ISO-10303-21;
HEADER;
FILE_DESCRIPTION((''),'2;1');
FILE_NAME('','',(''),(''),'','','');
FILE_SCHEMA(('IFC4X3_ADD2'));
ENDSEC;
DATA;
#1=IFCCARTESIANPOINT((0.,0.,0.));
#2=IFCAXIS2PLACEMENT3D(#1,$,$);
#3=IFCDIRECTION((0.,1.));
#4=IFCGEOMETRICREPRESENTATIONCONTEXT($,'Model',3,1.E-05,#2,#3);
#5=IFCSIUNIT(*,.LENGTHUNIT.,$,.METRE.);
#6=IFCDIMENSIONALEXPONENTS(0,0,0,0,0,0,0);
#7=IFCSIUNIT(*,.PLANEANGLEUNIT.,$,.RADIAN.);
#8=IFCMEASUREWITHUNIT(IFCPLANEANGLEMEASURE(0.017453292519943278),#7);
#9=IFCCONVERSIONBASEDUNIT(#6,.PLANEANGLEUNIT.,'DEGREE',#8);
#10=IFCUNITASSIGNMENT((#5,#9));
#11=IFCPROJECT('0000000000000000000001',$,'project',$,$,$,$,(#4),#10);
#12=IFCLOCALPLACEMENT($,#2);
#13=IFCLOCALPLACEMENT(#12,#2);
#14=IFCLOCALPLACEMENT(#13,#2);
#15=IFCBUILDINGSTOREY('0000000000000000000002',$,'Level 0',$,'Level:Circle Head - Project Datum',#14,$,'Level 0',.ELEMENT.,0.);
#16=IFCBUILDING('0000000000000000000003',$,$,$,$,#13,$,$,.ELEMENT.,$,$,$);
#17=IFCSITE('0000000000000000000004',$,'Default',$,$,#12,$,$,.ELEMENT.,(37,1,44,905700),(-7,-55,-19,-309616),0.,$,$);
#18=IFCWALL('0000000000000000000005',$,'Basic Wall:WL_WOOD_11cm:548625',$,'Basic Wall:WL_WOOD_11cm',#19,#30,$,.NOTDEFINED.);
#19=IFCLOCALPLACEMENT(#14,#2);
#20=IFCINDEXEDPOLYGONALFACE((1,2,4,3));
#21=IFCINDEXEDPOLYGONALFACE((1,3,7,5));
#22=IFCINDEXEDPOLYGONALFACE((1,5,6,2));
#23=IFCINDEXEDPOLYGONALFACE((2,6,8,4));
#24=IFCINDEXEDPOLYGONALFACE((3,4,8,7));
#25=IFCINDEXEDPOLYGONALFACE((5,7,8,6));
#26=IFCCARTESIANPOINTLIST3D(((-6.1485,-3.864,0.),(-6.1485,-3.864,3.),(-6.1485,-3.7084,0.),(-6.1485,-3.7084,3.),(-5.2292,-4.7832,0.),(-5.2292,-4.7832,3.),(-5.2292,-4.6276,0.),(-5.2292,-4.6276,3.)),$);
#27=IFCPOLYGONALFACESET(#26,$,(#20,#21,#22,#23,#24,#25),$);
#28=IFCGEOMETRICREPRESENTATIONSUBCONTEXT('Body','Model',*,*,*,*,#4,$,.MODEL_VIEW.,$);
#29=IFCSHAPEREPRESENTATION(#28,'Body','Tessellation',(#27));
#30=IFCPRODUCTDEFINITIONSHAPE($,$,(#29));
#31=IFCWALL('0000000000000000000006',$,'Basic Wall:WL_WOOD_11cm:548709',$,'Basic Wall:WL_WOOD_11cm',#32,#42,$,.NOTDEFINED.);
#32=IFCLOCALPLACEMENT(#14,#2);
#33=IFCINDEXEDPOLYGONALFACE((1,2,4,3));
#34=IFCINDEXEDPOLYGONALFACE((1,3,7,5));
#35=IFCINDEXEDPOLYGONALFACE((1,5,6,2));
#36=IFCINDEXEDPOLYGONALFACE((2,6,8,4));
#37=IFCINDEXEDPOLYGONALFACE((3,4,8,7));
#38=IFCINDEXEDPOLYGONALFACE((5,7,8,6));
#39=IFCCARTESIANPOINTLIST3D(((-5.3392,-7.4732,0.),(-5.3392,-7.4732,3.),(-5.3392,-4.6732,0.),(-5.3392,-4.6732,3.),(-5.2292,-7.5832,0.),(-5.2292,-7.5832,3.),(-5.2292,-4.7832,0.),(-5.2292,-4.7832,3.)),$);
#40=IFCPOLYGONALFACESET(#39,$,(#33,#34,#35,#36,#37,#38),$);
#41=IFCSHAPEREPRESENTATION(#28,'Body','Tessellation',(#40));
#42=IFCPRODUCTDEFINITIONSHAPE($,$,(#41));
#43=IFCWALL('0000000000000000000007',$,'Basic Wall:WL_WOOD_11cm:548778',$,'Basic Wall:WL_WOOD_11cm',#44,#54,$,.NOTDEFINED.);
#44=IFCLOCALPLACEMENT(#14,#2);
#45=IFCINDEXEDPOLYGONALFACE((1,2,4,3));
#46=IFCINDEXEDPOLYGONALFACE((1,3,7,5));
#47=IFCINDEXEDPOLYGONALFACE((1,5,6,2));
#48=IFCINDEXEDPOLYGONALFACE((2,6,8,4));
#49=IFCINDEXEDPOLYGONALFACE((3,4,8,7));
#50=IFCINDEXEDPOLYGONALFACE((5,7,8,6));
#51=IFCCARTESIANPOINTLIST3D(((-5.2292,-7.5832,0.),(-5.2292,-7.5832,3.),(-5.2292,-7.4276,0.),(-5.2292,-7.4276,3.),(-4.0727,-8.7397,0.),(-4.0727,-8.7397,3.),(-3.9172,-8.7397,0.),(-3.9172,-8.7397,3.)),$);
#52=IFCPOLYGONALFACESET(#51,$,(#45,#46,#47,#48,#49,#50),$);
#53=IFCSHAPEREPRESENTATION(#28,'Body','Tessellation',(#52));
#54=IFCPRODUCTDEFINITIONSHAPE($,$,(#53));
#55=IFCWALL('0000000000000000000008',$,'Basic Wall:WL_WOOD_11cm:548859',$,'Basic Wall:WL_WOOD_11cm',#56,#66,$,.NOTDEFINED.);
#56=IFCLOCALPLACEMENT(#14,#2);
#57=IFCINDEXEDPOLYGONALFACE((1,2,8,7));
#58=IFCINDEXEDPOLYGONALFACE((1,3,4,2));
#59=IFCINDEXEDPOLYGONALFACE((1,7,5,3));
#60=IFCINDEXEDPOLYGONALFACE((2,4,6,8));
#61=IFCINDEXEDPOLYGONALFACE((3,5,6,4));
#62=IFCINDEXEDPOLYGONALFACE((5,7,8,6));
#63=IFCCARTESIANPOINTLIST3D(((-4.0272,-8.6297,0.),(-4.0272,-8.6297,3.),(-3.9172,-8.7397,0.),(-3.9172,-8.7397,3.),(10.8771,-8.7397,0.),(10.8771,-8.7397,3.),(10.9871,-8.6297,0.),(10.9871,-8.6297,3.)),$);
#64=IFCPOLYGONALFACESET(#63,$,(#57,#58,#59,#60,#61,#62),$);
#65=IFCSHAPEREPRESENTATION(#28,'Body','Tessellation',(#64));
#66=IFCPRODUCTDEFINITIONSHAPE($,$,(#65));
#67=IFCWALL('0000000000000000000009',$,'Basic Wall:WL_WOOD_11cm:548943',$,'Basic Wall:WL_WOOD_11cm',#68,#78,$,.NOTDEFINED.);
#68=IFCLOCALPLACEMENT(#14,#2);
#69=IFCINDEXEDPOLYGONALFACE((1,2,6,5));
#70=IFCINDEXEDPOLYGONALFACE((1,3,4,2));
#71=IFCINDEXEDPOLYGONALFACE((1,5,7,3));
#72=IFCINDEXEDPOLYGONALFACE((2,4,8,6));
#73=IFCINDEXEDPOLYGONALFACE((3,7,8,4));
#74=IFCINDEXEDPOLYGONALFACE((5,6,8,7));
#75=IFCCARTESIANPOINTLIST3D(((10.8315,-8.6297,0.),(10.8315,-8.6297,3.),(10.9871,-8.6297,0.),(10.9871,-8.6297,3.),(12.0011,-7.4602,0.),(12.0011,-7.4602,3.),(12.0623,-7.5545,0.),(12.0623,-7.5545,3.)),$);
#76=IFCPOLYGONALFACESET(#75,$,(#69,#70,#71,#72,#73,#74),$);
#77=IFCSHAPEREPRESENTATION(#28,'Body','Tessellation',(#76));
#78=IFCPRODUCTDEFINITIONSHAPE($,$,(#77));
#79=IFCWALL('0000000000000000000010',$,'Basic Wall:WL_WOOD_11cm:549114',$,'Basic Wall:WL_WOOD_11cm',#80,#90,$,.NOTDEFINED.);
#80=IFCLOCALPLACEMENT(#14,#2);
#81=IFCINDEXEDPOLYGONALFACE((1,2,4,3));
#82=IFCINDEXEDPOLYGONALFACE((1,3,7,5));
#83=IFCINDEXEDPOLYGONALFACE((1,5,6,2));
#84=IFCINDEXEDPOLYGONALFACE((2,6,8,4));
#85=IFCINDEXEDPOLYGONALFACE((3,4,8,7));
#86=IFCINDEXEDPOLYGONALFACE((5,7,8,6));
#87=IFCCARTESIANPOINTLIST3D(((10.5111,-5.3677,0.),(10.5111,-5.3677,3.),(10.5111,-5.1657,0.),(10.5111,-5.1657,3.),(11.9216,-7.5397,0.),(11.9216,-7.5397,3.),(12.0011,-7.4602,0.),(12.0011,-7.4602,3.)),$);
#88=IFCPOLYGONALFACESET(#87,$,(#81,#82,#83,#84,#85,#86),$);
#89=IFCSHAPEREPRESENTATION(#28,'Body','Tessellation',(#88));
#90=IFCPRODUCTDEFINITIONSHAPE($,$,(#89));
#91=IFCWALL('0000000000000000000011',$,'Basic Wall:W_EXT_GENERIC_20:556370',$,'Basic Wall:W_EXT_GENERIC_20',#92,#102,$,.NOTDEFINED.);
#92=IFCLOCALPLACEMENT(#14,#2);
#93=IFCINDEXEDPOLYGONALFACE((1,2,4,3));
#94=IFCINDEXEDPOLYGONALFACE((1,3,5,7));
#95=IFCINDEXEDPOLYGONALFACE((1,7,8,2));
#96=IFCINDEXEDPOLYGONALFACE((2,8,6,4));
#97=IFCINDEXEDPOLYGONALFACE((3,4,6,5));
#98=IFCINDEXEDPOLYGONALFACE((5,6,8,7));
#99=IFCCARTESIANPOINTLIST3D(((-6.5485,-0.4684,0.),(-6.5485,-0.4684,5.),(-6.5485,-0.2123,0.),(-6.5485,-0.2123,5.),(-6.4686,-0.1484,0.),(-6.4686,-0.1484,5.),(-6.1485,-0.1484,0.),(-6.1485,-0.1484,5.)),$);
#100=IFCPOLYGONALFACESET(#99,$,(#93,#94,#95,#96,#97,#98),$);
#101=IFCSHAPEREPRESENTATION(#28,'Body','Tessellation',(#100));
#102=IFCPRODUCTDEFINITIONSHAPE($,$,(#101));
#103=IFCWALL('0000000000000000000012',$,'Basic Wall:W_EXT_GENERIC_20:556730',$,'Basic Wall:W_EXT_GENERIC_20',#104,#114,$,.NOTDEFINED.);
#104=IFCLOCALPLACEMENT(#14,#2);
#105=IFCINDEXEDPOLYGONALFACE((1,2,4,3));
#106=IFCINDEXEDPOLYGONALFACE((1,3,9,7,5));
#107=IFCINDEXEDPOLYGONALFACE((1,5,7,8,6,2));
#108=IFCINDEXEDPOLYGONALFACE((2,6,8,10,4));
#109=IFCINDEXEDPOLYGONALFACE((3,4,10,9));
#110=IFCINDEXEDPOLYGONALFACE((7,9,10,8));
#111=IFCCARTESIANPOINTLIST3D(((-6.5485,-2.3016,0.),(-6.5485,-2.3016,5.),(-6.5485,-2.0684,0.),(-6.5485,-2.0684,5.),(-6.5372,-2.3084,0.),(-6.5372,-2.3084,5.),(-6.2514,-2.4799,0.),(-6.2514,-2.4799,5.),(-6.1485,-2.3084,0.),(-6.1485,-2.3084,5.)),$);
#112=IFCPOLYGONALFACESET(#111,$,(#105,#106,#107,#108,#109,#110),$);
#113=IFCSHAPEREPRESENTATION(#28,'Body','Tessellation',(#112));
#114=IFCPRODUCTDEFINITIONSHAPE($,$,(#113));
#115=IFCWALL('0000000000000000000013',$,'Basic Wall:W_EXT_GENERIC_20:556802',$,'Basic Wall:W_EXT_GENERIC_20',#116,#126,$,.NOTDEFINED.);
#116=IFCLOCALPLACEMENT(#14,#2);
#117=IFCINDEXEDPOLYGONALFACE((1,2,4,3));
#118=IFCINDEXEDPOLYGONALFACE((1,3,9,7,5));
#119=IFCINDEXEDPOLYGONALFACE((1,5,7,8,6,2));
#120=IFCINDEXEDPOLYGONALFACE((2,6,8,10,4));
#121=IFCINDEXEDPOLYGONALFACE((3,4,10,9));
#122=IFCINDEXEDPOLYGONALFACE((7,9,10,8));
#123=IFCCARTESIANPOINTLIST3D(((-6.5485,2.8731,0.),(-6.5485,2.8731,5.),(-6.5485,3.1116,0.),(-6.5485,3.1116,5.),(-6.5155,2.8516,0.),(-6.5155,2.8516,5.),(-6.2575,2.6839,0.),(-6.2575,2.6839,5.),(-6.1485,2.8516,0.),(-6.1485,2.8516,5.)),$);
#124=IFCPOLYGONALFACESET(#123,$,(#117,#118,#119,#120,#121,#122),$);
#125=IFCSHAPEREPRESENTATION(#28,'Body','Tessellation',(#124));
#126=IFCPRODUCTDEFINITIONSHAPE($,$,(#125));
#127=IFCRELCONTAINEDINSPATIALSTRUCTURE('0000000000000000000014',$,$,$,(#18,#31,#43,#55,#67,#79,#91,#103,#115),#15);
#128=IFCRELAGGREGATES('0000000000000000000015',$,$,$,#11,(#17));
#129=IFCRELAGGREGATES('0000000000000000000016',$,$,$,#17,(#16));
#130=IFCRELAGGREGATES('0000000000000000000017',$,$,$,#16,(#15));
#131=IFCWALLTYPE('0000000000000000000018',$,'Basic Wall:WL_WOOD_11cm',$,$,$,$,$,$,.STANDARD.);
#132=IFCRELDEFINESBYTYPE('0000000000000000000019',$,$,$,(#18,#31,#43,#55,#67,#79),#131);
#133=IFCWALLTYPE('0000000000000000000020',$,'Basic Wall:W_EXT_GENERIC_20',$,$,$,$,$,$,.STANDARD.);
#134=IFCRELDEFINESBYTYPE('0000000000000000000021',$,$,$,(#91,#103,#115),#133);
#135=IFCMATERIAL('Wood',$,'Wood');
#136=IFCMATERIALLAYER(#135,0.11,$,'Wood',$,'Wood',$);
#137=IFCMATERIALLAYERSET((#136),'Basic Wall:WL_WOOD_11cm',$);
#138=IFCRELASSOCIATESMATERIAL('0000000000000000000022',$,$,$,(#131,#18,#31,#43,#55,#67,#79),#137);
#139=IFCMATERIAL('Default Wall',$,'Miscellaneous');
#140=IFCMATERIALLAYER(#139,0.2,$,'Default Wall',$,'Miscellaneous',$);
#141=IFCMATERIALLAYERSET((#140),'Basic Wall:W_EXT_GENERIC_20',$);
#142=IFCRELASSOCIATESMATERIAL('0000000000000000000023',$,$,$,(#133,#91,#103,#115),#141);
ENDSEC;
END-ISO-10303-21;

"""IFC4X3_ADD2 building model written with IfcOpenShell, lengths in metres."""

from ifc_helpers import new_model, entity, si_unit, converted_unit, direction, frame, origin, place, context, subcontext, project, spatial, polyline, outline, extrude, clip, bounded_halfspace, material, layer, layer_set, type_object, element, save


model = new_model("IFC4X3_ADD2")

# Units and contexts
model_context = context("Model", 3, precision=1e-05, world=origin(), true_north=direction((0.0, 1.0)))
body_context = subcontext(model_context, "Body", "Model", "MODEL_VIEW")
ifc_project = project(units=[si_unit("LENGTHUNIT", "METRE"), converted_unit("PLANEANGLEUNIT", "DEGREE", entity("IfcPlaneAngleMeasure", 0.017453292519943278), si_unit("PLANEANGLEUNIT", "RADIAN"), dimensions=[0, 0, 0, 0, 0, 0, 0])], contexts=[model_context])

# Site, building, storey
site_placement = place(None, origin())
site = spatial("IfcSite", under=ifc_project, at=site_placement, Name="Default", CompositionType="ELEMENT", RefLatitude=(37, 1, 44, 905700), RefLongitude=(-7, -55, -19, -309616), RefElevation=0.0)
building_placement = place(site_placement, origin())
building = spatial("IfcBuilding", under=site, at=building_placement, CompositionType="ELEMENT")
storey_placement = place(building_placement, origin())
storey = spatial("IfcBuildingStorey", under=building, at=storey_placement, Name="Level 0", ObjectType="Level:Circle Head - Project Datum", LongName="Level 0", CompositionType="ELEMENT", Elevation=0.0)

# Shared definitions
ifc_material_1 = material(Name="Default Wall", Category="Miscellaneous")

# Walls
ifc_material_2 = material(Name="Wood", Category="Wood")
ifc_layer_1 = layer(ifc_material_2, 0.11, Name="Wood", Category="Wood")
ifc_layer_set_1 = layer_set([ifc_layer_1], Name="Basic Wall:WL_WOOD_11cm")
wall_type_1 = type_object("IfcWallType", Name="Basic Wall:WL_WOOD_11cm", PredefinedType="STANDARD", material=ifc_layer_set_1)
wall_1_placement = place(storey_placement, frame((-6.1874, -3.7473, 0.0), z_axis=(0.0, 0.0, 1.0), x_axis=(0.707107, -0.707107, 0.0)))
element("IfcWall", 1, at=wall_1_placement, inside=storey, type_object=wall_type_1, material=ifc_layer_set_1, Name="Basic Wall:WL_WOOD_11cm:548625", ObjectType="Basic Wall:WL_WOOD_11cm", PredefinedType="NOTDEFINED", context=body_context, shape_type="Clipping", body=[
    clip(extrude(outline(polyline([(1.41, -0.055), (1.3, 0.055), (0.0, 0.055), (0.11, -0.055), (1.2544, -0.055), (1.41, -0.055)])), origin(), (0.0, 0.0, 1.0), 3.0), bounded_halfspace(frame((0.11, -0.055, 3.0), z_axis=(0.0, 0.0, -1.0), x_axis=(0.707107, 0.707107, 0.0)), True, frame((0.11, -0.055, 3.0)), polyline([(0.0, 0.0), (1.1444, 0.0), (1.3, 0.0), (1.19, 0.11), (-0.11, 0.11), (0.0, 0.0)]))),
])
wall_2_placement = place(storey_placement, frame((-5.2842, -4.6732, 0.0), z_axis=(0.0, 0.0, 1.0), x_axis=(0.0, -1.0, 0.0)))
element("IfcWall", 2, at=wall_2_placement, inside=storey, type_object=wall_type_1, material=ifc_layer_set_1, Name="Basic Wall:WL_WOOD_11cm:548709", ObjectType="Basic Wall:WL_WOOD_11cm", PredefinedType="NOTDEFINED", context=body_context, shape_type="Clipping", body=[
    clip(extrude(outline(polyline([(2.8, -0.055), (2.91, 0.055), (2.7544, 0.055), (0.11, 0.055), (0.0, -0.055), (2.8, -0.055)])), origin(), (0.0, 0.0, 1.0), 3.0), bounded_halfspace(frame((0.0, -0.055, 3.0), z_axis=(0.0, 0.0, -1.0), x_axis=(0.0, 1.0, 0.0)), True, frame((0.0, -0.055, 3.0)), polyline([(0.0, 0.0), (2.8, 0.0), (2.91, 0.11), (2.7544, 0.11), (0.11, 0.11), (0.0, 0.0)]))),
])
wall_3_placement = place(storey_placement, frame((-5.2681, -7.4665, 0.0), z_axis=(0.0, 0.0, 1.0), x_axis=(0.707107, -0.707107, 0.0)))
element("IfcWall", 3, at=wall_3_placement, inside=storey, type_object=wall_type_1, material=ifc_layer_set_1, Name="Basic Wall:WL_WOOD_11cm:548778", ObjectType="Basic Wall:WL_WOOD_11cm", PredefinedType="NOTDEFINED", context=body_context, shape_type="Clipping", body=[
    clip(extrude(outline(polyline([(1.7456, -0.055), (1.8556, 0.055), (1.7, 0.055), (0.0, 0.055), (0.11, -0.055), (1.7456, -0.055)])), origin(), (0.0, 0.0, 1.0), 3.0), bounded_halfspace(frame((0.11, -0.055, 3.0), z_axis=(0.0, 0.0, -1.0), x_axis=(0.707107, 0.707107, 0.0)), True, frame((0.11, -0.055, 3.0)), polyline([(0.0, 0.0), (1.6356, 0.0), (1.7456, 0.11), (1.59, 0.11), (-0.11, 0.11), (0.0, 0.0)]))),
])
wall_4_placement = place(storey_placement, frame((-4.0272, -8.6847, 0.0)))
element("IfcWall", 4, at=wall_4_placement, inside=storey, type_object=wall_type_1, material=ifc_layer_set_1, Name="Basic Wall:WL_WOOD_11cm:548859", ObjectType="Basic Wall:WL_WOOD_11cm", PredefinedType="NOTDEFINED", context=body_context, shape_type="Clipping", body=[
    clip(extrude(outline(polyline([(14.9042, -0.055), (15.0142, 0.055), (14.8587, 0.055), (0.0, 0.055), (0.11, -0.055), (14.9042, -0.055)])), origin(), (0.0, 0.0, 1.0), 3.0), bounded_halfspace(frame((0.11, -0.055, 3.0), z_axis=(0.0, 0.0, -1.0), x_axis=(1.0, 0.0, 0.0)), True, frame((0.11, -0.055, 3.0)), polyline([(0.0, 0.0), (14.7942, 0.0), (14.9042, 0.11), (14.7487, 0.11), (-0.11, 0.11), (0.0, 0.0)]))),
])
wall_5_placement = place(storey_placement, frame((12.04, -7.499, 0.0), z_axis=(0.0, 0.0, 1.0), x_axis=(-0.707107, -0.707107, 0.0)))
element("IfcWall", 5, at=wall_5_placement, inside=storey, type_object=wall_type_1, material=ifc_layer_set_1, Name="Basic Wall:WL_WOOD_11cm:548943", ObjectType="Basic Wall:WL_WOOD_11cm", PredefinedType="NOTDEFINED", context=body_context, shape_type="Clipping", body=[
    clip(extrude(outline(polyline([(1.654, -0.055), (1.544, 0.055), (0.0234, 0.055), (0.0, -0.055), (0.1125, -0.055), (1.654, -0.055)])), origin(), (0.0, 0.0, 1.0), 3.0), bounded_halfspace(frame((0.0, -0.055, 3.0), z_axis=(0.0, 0.0, -1.0), x_axis=(-0.707107, 0.707107, 0.0)), True, frame((0.0, -0.055, 3.0)), polyline([(0.0, 0.0), (0.1125, 0.0), (1.654, 0.0), (1.544, 0.11), (0.0234, 0.11), (0.0, 0.0)]))),
])
wall_6_placement = place(storey_placement, frame((10.4649, -5.1957, 0.0), z_axis=(0.0, 0.0, 1.0), x_axis=(0.544639, -0.838671, 0.0)))
element("IfcWall", 6, at=wall_6_placement, inside=storey, type_object=wall_type_1, material=ifc_layer_set_1, Name="Basic Wall:WL_WOOD_11cm:549114", ObjectType="Basic Wall:WL_WOOD_11cm", PredefinedType="NOTDEFINED", context=body_context, shape_type="Clipping", body=[
    clip(extrude(outline(polyline([(2.7592, -0.055), (2.7358, 0.055), (0.202, 0.055), (0.0, 0.055), (0.1694, -0.055), (2.7592, -0.055)])), origin(), (0.0, 0.0, 1.0), 3.0), bounded_halfspace(frame((0.1694, -0.055, 3.0), z_axis=(0.0, 0.0, -1.0), x_axis=(0.544639, 0.838671, 0.0)), True, frame((0.1694, -0.055, 3.0)), polyline([(0.0, 0.0), (2.5898, 0.0), (2.5664, 0.11), (0.0326, 0.11), (-0.1694, 0.11), (0.0, 0.0)]))),
])

# Walls
ifc_layer_2 = layer(ifc_material_1, 0.2, Name="Default Wall", Category="Miscellaneous")
ifc_layer_set_2 = layer_set([ifc_layer_2], Name="Basic Wall:W_EXT_GENERIC_20")
wall_type_2 = type_object("IfcWallType", Name="Basic Wall:W_EXT_GENERIC_20", PredefinedType="STANDARD", material=ifc_layer_set_2)
wall_7_placement = place(storey_placement, frame((-6.2109, -0.0703, 0.0), z_axis=(0.0, 0.0, 1.0), x_axis=(-0.780869, -0.624695, 0.0)))
element("IfcWall", 7, at=wall_7_placement, inside=storey, type_object=wall_type_2, material=ifc_layer_set_2, Name="Basic Wall:W_EXT_GENERIC_20:556370", ObjectType="Basic Wall:W_EXT_GENERIC_20", PredefinedType="NOTDEFINED", context=body_context, shape_type="SweptSolid", body=[
    extrude(outline(polyline([(0.0, 0.1), (0.25, -0.1), (0.3522, -0.1), (0.5122, 0.1), (0.0, 0.1)])), origin(), (0.0, 0.0, 1.0), 5.0),
])
wall_8_placement = place(storey_placement, frame((-6.1999, -2.3942, 0.0), z_axis=(0.0, 0.0, 1.0), x_axis=(-0.857493, 0.514496, 0.0)))
element("IfcWall", 8, at=wall_8_placement, inside=storey, type_object=wall_type_2, material=ifc_layer_set_2, Name="Basic Wall:W_EXT_GENERIC_20:556730", ObjectType="Basic Wall:W_EXT_GENERIC_20", PredefinedType="NOTDEFINED", context=body_context, shape_type="SweptSolid", body=[
    extrude(outline(polyline([(0.4665, -0.1), (0.3465, 0.1), (0.3333, 0.1), (0.0, 0.1), (0.0, -0.1), (0.4665, -0.1)])), origin(), (0.0, 0.0, 1.0), 5.0),
])
wall_9_placement = place(storey_placement, frame((-6.203, 2.7677, 0.0), z_axis=(0.0, 0.0, 1.0), x_axis=(-0.838444, 0.544988, 0.0)))
element("IfcWall", 9, at=wall_9_placement, inside=storey, type_object=wall_type_2, material=ifc_layer_set_2, Name="Basic Wall:W_EXT_GENERIC_20:556802", ObjectType="Basic Wall:W_EXT_GENERIC_20", PredefinedType="NOTDEFINED", context=body_context, shape_type="SweptSolid", body=[
    extrude(outline(polyline([(0.4771, -0.1), (0.3471, 0.1), (0.3077, 0.1), (0.0, 0.1), (0.0, -0.1), (0.4771, -0.1)])), origin(), (0.0, 0.0, 1.0), 5.0),
])

save(model, "model.ifc")
